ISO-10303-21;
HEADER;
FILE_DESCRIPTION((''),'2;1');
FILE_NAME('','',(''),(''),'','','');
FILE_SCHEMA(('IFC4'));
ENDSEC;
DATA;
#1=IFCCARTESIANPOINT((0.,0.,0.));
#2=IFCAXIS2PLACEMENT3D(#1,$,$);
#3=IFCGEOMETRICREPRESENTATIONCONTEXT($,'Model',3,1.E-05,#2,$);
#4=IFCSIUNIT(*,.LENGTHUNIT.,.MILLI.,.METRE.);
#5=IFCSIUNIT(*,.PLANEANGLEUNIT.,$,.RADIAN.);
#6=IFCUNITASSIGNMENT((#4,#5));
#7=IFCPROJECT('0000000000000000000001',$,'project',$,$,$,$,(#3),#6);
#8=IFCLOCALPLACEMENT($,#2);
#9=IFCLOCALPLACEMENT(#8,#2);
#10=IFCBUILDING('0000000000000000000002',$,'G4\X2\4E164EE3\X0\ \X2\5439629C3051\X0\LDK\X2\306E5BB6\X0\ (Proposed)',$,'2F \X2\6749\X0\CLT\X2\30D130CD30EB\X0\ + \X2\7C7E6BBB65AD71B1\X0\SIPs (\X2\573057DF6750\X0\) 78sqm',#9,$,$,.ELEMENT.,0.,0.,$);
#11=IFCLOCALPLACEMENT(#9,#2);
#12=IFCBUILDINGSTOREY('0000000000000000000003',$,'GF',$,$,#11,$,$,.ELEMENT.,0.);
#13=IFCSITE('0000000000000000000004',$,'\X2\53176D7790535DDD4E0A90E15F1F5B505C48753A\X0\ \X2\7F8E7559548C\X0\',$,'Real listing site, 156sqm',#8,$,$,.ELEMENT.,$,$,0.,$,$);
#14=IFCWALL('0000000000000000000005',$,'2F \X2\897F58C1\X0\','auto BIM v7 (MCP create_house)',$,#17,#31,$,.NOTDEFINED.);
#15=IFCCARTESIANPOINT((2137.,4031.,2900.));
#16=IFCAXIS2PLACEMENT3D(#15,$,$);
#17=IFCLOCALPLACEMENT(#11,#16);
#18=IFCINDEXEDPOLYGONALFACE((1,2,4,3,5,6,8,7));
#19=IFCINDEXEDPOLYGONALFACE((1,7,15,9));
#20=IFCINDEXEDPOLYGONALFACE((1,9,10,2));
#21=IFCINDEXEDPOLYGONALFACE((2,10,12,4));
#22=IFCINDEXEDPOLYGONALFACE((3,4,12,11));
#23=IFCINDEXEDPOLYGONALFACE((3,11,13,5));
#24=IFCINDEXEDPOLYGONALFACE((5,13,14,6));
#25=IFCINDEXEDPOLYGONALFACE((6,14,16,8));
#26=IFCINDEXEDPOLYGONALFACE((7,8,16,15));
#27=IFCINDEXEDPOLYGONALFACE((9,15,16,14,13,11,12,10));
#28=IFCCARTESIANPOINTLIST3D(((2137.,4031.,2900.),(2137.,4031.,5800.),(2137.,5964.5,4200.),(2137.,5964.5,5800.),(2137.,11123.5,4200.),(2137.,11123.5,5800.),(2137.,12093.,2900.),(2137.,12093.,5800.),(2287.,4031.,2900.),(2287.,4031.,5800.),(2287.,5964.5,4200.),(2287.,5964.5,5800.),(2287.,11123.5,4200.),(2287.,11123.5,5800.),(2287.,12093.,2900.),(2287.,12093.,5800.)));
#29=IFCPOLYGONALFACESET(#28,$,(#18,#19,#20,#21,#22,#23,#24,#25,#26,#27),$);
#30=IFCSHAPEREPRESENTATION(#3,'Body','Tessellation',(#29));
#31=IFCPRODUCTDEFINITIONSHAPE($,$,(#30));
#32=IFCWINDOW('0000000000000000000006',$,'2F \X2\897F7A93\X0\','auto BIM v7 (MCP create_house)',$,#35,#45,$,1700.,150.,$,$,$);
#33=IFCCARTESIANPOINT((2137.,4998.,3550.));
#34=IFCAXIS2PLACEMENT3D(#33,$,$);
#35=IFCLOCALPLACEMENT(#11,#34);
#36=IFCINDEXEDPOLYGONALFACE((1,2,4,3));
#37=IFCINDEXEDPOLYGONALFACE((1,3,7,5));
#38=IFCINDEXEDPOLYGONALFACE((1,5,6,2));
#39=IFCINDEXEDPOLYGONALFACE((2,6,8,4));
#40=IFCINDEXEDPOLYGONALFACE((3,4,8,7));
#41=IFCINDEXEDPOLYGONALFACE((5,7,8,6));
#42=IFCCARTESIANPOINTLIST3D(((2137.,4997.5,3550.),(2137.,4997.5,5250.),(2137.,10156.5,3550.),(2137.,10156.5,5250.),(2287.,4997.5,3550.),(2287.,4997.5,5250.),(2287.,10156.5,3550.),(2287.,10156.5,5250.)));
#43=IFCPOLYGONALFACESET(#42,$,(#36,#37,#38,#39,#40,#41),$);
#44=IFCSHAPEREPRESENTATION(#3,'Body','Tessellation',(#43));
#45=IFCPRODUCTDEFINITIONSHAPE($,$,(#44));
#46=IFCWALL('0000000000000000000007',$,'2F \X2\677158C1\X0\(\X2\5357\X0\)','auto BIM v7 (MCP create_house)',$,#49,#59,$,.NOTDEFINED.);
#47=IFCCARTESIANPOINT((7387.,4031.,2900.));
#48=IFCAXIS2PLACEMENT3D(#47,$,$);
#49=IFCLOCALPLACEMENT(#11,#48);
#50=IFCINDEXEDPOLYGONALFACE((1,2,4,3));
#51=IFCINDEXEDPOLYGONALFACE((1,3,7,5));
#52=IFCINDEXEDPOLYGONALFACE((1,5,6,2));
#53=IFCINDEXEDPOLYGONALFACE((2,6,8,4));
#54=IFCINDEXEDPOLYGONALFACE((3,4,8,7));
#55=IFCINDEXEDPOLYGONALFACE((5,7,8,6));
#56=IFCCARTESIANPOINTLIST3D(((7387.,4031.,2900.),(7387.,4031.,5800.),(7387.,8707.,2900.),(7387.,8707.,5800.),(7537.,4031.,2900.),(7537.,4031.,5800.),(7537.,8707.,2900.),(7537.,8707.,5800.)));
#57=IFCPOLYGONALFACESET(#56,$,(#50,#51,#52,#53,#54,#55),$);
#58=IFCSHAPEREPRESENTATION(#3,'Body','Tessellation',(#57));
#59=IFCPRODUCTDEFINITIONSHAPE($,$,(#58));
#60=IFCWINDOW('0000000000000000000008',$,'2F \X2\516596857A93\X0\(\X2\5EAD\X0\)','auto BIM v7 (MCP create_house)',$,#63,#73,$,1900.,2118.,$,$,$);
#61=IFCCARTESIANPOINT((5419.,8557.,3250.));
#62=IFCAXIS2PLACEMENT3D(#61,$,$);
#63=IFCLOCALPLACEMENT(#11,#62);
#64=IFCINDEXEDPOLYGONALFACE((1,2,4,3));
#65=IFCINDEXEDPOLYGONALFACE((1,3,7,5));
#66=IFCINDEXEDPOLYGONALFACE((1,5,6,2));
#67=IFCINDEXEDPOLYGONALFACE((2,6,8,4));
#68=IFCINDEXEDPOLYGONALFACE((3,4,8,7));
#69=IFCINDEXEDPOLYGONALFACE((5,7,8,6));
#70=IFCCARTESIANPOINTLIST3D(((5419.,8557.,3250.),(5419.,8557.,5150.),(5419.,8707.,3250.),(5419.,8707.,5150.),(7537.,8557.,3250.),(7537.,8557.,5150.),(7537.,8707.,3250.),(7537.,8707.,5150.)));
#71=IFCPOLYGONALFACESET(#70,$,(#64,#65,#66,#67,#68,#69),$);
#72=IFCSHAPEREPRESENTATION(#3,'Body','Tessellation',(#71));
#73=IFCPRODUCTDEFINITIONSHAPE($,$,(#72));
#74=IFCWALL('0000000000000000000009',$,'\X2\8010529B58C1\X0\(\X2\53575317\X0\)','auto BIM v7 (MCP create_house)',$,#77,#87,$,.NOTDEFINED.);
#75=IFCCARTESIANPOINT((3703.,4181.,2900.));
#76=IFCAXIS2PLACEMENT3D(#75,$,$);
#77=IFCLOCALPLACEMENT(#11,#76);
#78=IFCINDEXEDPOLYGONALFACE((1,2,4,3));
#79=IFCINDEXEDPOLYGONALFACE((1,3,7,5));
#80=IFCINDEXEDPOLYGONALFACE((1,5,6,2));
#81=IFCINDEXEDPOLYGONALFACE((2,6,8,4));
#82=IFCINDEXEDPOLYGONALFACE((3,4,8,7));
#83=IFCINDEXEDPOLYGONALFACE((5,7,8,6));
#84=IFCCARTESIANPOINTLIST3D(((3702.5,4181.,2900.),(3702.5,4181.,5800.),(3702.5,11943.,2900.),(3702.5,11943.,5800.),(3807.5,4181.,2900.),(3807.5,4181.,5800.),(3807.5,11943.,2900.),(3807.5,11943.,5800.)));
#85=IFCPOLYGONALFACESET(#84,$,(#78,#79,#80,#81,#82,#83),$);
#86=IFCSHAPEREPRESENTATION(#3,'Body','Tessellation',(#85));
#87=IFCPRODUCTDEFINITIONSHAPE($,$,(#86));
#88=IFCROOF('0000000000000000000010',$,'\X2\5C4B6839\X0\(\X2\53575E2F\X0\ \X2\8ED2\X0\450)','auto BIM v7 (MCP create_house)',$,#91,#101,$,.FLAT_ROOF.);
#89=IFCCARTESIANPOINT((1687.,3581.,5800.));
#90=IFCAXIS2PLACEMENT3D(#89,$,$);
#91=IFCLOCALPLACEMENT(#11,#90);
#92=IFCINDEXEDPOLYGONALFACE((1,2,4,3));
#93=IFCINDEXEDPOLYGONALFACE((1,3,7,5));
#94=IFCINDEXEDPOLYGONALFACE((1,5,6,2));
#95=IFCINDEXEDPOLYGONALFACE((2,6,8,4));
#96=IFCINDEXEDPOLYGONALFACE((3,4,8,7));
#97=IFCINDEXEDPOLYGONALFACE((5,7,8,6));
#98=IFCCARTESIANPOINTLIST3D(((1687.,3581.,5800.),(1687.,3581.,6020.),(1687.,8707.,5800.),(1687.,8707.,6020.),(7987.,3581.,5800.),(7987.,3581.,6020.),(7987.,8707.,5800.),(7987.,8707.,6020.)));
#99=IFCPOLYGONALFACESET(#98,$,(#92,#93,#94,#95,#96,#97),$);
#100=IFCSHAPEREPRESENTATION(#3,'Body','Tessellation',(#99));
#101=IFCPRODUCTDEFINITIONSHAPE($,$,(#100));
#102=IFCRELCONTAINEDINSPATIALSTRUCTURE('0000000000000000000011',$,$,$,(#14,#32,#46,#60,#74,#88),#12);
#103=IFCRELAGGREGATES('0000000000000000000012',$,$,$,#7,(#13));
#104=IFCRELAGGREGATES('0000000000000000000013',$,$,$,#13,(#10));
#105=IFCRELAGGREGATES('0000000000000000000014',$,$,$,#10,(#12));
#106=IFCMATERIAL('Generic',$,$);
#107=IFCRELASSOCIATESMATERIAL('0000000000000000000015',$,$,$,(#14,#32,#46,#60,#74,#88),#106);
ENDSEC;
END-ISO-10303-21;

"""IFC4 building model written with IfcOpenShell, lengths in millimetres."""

from ifc_helpers import new_model, si_unit, frame, frame_2d, origin, place, context, project, spatial, rectangle, extrude, material, element, fill, save


model = new_model("IFC4")

# Units and contexts
model_context = context("Model", 3, precision=1e-05, world=origin())
ifc_project = project(units=[si_unit("LENGTHUNIT", "METRE", prefix="MILLI"), si_unit("PLANEANGLEUNIT", "RADIAN")], contexts=[model_context])

# Site, building, storey
site_placement = place(None, origin())
site = spatial("IfcSite", under=ifc_project, at=site_placement, Name="北海道川上郡弟子屈町 美留和", ObjectType="Real listing site, 156sqm", CompositionType="ELEMENT", RefElevation=0.0)
building_placement = place(site_placement, origin())
building = spatial("IfcBuilding", under=site, at=building_placement, Name="G4世代 吹抜けLDKの家 (Proposed)", ObjectType="2F 杉CLTパネル + 籾殻断熱SIPs (地域材) 78sqm", CompositionType="ELEMENT", ElevationOfRefHeight=0.0, ElevationOfTerrain=0.0)
storey_placement = place(building_placement, origin())
storey = spatial("IfcBuildingStorey", under=building, at=storey_placement, Name="GF", CompositionType="ELEMENT", Elevation=0.0)

# Shared definitions
ifc_material = material(Name="Generic")

# Walls, openings, windows
wall_1_placement = place(storey_placement, frame((2137.0, 4031.0, 2900.0)))
wall_1 = element("IfcWall", 1, at=wall_1_placement, inside=storey, material=ifc_material, Name="2F 西壁", Description="auto BIM v7 (MCP create_house)", PredefinedType="NOTDEFINED", context=model_context, shape_type="SweptSolid", body=[
    extrude(rectangle(XDim=150.0, YDim=8062.0, at=frame_2d((75.0, 4031.0))), frame((2137.0, 4031.0, 2900.0)), (0.0, 0.0, 1.0), 2900.0),
])
opening_1_placement = place(storey_placement, frame((2137.0, 4998.0, 3550.0)))
opening_1 = element("IfcOpeningElement", 2, at=opening_1_placement, cuts=wall_1, PredefinedType="NOTDEFINED", context=model_context, shape_type="SweptSolid", body=[
    extrude(rectangle(XDim=150.0, YDim=5159.0, at=frame_2d((75.0, 2579.0))), frame((2137.0, 4998.0, 3550.0)), (0.0, 0.0, 1.0), 1700.0),
])
window_1_placement = place(storey_placement, frame((2137.0, 4998.0, 3550.0)))
window_1 = element("IfcWindow", 3, at=window_1_placement, inside=storey, material=ifc_material, Name="2F 西窓", Description="auto BIM v7 (MCP create_house)", OverallHeight=1700.0, OverallWidth=150.0, context=model_context, shape_type="SweptSolid", body=[
    extrude(rectangle(XDim=150.0, YDim=5159.0, at=frame_2d((75.0, 2579.0))), frame((2137.0, 4998.0, 3550.0)), (0.0, 0.0, 1.0), 1700.0),
])
fill(opening_1, window_1)
wall_2_placement = place(storey_placement, frame((7387.0, 4031.0, 2900.0)))
wall_2 = element("IfcWall", 4, at=wall_2_placement, inside=storey, material=ifc_material, Name="2F 東壁(南)", Description="auto BIM v7 (MCP create_house)", PredefinedType="NOTDEFINED", context=model_context, shape_type="SweptSolid", body=[
    extrude(rectangle(XDim=150.0, YDim=4676.0, at=frame_2d((75.0, 2338.0))), frame((7387.0, 4031.0, 2900.0)), (0.0, 0.0, 1.0), 2900.0),
])
opening_2_placement = place(storey_placement, frame((5419.0, 8557.0, 3250.0)))
opening_2 = element("IfcOpeningElement", 5, at=opening_2_placement, cuts=wall_2, PredefinedType="NOTDEFINED", context=model_context, shape_type="SweptSolid", body=[
    extrude(rectangle(XDim=2118.0, YDim=150.0, at=frame_2d((1059.0, 75.0))), frame((5419.0, 8557.0, 3250.0)), (0.0, 0.0, 1.0), 1900.0),
])
window_2_placement = place(storey_placement, frame((5419.0, 8557.0, 3250.0)))
window_2 = element("IfcWindow", 6, at=window_2_placement, inside=storey, material=ifc_material, Name="2F 入隅窓(庭)", Description="auto BIM v7 (MCP create_house)", OverallHeight=1900.0, OverallWidth=2118.0, context=model_context, shape_type="SweptSolid", body=[
    extrude(rectangle(XDim=2118.0, YDim=150.0, at=frame_2d((1059.0, 75.0))), frame((5419.0, 8557.0, 3250.0)), (0.0, 0.0, 1.0), 1900.0),
])
fill(opening_2, window_2)

# Wall
wall_3_placement = place(storey_placement, frame((3703.0, 4181.0, 2900.0)))
element("IfcWall", 7, at=wall_3_placement, inside=storey, material=ifc_material, Name="耐力壁(南北)", Description="auto BIM v7 (MCP create_house)", PredefinedType="NOTDEFINED", context=model_context, shape_type="SweptSolid", body=[
    extrude(rectangle(XDim=105.0, YDim=7762.0, at=frame_2d((52.0, 3881.0))), frame((3703.0, 4181.0, 2900.0)), (0.0, 0.0, 1.0), 2900.0),
])

# Roof
for number, where, name in (
    (8, (1687.0, 3581.0, 5800.0), "屋根(南帯 軒450)"),
):
    element("IfcRoof", number, at=place(storey_placement, frame(where)), inside=storey, material=ifc_material, Name=name, Description="auto BIM v7 (MCP create_house)", PredefinedType="FLAT_ROOF", context=model_context, shape_type="SweptSolid", body=[
        extrude(rectangle(XDim=6300.0, YDim=5126.0, at=frame_2d((3150.0, 2563.0))), frame((1687.0, 3581.0, 5800.0)), (0.0, 0.0, 1.0), 220.0),
    ])

save(model, "model.ifc")
